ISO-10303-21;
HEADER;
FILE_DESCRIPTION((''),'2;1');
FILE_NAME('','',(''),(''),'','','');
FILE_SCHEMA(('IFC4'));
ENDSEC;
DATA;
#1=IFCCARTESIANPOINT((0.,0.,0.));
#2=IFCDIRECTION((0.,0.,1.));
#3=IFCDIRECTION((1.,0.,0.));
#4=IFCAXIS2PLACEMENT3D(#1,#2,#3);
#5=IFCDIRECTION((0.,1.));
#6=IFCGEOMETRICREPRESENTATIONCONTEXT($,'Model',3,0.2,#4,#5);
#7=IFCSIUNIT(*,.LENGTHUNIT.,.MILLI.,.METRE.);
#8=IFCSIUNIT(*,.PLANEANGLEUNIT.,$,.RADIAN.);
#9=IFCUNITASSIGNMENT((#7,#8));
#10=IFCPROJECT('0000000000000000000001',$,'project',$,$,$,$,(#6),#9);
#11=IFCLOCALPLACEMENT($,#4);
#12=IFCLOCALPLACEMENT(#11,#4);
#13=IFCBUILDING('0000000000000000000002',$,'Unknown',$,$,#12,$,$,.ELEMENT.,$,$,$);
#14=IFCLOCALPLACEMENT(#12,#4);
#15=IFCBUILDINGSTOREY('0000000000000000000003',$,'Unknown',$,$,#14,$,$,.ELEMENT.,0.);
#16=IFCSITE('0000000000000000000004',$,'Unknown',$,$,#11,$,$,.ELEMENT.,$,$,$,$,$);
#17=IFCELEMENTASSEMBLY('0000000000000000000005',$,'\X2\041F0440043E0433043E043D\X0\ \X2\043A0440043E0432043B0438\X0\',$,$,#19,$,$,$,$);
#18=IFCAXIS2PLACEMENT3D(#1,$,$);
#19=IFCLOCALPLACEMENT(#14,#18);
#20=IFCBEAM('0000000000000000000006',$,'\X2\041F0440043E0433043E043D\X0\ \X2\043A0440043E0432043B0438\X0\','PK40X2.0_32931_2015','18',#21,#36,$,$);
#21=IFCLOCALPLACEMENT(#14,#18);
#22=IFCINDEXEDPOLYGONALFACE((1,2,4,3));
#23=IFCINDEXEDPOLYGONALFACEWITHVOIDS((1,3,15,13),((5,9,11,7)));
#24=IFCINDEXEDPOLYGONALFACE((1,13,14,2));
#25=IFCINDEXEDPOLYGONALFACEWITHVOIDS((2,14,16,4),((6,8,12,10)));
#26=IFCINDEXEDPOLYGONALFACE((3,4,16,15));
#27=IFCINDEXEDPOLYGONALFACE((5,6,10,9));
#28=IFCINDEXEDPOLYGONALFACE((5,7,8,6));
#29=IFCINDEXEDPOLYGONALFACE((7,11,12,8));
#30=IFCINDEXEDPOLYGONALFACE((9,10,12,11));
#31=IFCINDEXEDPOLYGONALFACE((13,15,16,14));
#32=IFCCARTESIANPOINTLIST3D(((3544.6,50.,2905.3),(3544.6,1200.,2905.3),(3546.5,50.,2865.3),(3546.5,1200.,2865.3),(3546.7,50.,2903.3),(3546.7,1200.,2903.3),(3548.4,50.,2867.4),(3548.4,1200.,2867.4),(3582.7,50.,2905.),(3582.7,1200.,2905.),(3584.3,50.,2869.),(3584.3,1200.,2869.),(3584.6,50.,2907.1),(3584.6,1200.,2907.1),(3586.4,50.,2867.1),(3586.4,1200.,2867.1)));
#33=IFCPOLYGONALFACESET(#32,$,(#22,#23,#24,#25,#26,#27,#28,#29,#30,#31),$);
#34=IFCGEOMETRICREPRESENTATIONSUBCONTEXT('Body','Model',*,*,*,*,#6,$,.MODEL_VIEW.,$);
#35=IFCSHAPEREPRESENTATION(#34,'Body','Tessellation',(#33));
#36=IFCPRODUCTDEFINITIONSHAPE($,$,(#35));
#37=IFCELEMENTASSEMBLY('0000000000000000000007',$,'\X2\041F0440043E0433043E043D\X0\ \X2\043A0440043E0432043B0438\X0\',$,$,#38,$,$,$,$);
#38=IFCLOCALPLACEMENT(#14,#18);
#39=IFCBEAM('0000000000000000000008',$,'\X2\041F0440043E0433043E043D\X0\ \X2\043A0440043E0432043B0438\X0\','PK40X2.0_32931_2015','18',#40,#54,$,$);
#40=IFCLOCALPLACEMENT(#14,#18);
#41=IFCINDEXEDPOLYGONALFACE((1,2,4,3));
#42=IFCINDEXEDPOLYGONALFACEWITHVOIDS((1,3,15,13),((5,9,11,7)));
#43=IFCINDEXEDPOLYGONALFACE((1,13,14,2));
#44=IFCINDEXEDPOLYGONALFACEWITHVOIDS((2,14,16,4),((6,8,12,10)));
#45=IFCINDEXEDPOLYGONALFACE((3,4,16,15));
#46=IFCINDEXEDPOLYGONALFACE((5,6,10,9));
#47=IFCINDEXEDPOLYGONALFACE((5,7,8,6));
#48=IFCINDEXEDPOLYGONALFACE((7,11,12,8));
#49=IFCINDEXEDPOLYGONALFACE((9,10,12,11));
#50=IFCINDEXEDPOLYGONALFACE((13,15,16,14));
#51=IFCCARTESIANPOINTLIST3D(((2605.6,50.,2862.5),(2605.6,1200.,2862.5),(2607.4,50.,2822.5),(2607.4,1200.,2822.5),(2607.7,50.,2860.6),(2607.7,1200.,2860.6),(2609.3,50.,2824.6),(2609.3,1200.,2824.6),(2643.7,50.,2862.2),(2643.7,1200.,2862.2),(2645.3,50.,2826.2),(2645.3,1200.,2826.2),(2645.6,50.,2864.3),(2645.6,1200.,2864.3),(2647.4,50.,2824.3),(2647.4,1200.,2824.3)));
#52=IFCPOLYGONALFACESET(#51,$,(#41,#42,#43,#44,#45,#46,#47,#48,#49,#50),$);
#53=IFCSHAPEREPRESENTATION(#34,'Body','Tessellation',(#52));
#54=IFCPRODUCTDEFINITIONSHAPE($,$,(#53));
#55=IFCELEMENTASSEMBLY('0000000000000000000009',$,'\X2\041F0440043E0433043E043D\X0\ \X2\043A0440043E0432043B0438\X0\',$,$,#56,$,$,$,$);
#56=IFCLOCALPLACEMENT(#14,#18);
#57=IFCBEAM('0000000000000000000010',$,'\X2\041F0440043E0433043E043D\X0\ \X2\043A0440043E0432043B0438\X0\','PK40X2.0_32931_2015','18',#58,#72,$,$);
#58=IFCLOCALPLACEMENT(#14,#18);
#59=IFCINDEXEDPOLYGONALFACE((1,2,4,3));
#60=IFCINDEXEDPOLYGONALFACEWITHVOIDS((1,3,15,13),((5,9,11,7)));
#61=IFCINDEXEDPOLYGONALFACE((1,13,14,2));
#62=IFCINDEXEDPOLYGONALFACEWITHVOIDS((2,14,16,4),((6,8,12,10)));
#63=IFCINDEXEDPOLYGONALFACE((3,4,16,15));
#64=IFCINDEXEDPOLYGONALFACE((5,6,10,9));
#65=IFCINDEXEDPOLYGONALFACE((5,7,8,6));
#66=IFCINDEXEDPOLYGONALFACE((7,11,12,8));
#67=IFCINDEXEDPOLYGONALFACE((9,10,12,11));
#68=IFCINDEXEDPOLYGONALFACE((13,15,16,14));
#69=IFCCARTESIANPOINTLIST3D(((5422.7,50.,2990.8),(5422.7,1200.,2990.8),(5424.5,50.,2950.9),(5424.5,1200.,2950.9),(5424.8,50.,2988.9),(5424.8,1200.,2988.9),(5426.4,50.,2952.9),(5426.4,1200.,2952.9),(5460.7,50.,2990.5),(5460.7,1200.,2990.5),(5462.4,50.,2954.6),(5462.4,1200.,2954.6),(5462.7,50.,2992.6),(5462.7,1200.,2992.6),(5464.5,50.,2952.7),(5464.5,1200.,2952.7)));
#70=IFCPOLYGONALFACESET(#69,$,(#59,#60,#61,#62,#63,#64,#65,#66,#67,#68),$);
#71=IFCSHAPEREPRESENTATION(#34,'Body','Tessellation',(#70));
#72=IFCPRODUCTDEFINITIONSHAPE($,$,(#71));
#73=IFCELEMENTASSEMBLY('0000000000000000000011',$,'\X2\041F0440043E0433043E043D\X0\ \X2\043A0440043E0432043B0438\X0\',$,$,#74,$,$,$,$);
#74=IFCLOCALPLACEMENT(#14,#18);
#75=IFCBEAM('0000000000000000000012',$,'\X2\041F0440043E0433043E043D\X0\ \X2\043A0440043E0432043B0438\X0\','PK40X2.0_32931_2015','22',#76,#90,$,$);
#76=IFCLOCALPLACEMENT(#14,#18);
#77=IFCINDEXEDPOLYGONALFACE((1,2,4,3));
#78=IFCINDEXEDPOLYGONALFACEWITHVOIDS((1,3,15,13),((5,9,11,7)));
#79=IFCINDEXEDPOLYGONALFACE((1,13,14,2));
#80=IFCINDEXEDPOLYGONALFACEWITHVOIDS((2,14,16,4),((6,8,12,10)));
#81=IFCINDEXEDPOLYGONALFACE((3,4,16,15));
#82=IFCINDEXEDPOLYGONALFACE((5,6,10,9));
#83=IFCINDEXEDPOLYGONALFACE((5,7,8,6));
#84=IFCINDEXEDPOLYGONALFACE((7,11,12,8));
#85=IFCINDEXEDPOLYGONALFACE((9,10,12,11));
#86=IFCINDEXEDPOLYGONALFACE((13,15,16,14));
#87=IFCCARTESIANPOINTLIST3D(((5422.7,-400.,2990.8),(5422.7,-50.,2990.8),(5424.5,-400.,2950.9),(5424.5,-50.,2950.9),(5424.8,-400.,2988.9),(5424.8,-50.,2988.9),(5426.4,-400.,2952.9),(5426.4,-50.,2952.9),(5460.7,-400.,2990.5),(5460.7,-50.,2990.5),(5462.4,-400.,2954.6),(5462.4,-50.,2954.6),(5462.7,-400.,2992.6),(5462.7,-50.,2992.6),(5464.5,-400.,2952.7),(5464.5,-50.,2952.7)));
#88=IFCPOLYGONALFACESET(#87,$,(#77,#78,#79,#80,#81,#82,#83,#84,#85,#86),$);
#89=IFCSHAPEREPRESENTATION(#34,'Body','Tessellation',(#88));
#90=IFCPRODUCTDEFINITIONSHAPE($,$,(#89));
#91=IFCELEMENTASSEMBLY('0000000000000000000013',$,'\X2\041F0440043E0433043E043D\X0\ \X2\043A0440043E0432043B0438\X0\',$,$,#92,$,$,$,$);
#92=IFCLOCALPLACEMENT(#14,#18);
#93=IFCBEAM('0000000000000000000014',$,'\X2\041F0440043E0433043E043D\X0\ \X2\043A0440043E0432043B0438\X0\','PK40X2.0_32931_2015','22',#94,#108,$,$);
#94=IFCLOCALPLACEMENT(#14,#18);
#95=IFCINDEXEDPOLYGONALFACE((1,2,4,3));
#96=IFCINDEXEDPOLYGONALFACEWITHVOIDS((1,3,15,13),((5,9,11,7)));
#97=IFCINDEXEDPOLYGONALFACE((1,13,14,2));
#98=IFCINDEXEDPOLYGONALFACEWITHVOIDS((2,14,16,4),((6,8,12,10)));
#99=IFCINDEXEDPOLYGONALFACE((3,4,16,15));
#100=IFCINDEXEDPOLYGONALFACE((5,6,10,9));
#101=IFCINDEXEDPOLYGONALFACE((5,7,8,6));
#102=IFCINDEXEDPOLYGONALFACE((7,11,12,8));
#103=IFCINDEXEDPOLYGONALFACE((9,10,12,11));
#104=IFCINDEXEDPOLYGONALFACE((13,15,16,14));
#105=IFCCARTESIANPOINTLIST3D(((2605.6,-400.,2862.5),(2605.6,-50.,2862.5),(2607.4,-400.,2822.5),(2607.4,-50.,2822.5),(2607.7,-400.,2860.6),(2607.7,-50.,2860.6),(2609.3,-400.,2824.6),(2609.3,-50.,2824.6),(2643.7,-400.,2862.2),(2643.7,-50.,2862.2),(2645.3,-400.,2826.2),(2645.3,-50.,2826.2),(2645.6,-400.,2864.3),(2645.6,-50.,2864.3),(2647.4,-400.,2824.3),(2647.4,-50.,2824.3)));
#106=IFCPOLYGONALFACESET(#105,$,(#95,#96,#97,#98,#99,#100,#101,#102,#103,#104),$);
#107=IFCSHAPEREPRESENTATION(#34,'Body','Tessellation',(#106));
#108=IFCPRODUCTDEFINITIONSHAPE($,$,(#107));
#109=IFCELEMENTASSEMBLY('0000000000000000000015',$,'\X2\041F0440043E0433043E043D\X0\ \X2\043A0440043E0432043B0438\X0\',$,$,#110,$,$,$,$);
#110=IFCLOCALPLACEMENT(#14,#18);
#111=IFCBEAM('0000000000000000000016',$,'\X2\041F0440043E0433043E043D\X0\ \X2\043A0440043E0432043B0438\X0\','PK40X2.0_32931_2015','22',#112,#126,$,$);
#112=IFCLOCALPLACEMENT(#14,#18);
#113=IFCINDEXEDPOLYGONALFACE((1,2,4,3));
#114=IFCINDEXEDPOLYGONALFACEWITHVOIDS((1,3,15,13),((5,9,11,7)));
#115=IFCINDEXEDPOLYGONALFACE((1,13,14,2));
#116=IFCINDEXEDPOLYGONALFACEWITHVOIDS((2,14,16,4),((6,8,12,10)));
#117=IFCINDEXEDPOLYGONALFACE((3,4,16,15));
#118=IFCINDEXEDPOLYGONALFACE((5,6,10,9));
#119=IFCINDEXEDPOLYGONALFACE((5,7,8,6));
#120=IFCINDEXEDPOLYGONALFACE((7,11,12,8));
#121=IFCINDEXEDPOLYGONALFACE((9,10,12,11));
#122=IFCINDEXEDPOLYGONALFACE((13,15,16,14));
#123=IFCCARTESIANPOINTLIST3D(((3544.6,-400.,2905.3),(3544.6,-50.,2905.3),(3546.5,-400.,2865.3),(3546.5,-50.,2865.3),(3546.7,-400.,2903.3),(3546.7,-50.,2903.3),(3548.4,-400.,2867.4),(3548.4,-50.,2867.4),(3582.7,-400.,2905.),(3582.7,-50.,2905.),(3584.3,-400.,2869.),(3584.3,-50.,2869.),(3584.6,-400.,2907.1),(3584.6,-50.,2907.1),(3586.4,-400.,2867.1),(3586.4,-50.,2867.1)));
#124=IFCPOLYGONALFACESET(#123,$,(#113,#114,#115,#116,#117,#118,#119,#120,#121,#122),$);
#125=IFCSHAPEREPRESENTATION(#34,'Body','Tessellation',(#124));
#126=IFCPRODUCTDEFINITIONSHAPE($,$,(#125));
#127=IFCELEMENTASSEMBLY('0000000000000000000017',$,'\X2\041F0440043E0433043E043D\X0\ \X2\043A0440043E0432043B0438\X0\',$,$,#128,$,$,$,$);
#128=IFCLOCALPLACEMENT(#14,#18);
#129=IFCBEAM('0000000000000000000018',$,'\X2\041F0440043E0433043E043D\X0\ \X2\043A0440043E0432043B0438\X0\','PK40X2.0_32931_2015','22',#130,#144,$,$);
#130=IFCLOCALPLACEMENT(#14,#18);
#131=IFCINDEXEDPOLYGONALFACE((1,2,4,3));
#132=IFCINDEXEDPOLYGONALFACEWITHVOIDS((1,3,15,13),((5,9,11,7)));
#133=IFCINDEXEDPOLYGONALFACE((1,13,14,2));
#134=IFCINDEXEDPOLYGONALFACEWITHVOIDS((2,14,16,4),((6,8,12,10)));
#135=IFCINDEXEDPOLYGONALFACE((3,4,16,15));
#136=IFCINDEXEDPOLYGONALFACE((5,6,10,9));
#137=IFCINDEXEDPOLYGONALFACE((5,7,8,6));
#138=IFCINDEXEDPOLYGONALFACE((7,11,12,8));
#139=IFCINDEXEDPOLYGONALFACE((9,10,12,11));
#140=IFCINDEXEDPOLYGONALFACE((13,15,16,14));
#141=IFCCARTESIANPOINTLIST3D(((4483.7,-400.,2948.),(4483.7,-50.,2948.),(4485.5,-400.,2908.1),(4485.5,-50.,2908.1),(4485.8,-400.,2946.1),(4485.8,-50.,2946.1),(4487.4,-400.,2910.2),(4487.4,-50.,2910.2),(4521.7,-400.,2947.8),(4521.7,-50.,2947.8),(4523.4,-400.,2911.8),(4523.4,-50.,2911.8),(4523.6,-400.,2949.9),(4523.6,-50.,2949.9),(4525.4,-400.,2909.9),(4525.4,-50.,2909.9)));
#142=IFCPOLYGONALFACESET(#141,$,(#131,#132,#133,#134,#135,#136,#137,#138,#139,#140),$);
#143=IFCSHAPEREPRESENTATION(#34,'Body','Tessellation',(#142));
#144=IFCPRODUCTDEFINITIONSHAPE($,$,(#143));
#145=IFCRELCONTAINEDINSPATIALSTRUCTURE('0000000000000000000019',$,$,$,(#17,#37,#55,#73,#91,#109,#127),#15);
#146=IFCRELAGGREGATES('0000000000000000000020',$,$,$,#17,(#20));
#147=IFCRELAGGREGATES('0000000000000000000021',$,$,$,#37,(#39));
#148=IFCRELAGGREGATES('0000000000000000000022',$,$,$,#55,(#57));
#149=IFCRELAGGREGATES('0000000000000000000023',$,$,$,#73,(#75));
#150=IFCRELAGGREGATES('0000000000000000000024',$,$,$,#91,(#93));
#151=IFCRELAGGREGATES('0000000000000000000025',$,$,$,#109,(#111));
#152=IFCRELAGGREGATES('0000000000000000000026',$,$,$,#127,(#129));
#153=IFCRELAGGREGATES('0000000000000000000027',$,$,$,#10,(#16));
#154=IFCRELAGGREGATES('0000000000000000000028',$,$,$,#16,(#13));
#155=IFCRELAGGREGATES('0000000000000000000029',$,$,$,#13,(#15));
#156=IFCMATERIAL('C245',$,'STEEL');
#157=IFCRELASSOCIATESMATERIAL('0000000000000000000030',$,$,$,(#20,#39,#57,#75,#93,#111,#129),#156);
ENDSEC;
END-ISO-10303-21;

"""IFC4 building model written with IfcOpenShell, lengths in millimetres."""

from ifc_helpers import new_model, si_unit, direction, frame, origin_with_axes, place, context, subcontext, project, spatial, line, indexed_curve, outline, extrude, material, element, aggregate, save


model = new_model("IFC4")

# Units and contexts
model_context = context("Model", 3, precision=0.2, world=origin_with_axes(), true_north=direction((0.0, 1.0)))
body_context = subcontext(model_context, "Body", "Model", "MODEL_VIEW")
ifc_project = project(units=[si_unit("LENGTHUNIT", "METRE", prefix="MILLI"), si_unit("PLANEANGLEUNIT", "RADIAN")], contexts=[model_context])

# Site, building, storey
site_placement = place(None, origin_with_axes())
site = spatial("IfcSite", under=ifc_project, at=site_placement, Name="Unknown", CompositionType="ELEMENT")
building_placement = place(site_placement, origin_with_axes())
building = spatial("IfcBuilding", under=site, at=building_placement, Name="Unknown", CompositionType="ELEMENT")
storey_placement = place(building_placement, origin_with_axes())
storey = spatial("IfcBuildingStorey", under=building, at=storey_placement, Name="Unknown", CompositionType="ELEMENT", Elevation=0.0)

# Shared definitions
ifc_material = material(Name="C245", Category="STEEL")

# Element assemblies, beams
assembly_1_placement = place(storey_placement, frame((3565.5, 1200.0, 2886.2), z_axis=(-0.998964, 0.0, -0.045508), x_axis=(0.0, -1.0, 0.0)))
assembly_1 = element("IfcElementAssembly", 1, at=assembly_1_placement, inside=storey, Name="Прогон кровли")
beam_1_placement = place(assembly_1_placement, origin_with_axes())
beam_1 = element("IfcBeam", 2, at=beam_1_placement, material=ifc_material, Name="Прогон кровли", Description="PK40X2.0_32931_2015", ObjectType="18", context=body_context, shape_type="SolidModel", body=[
    extrude(outline(indexed_curve([(-20.0, -20.0), (20.0, -20.0), (20.0, 20.0), (-20.0, 20.0)], segments=[line(1, 2, 3, 4, 1)]), holes=[indexed_curve([(-18.0, -18.0), (-18.0, 18.0), (18.0, 18.0), (18.0, -18.0)], segments=[line(1, 2, 3, 4, 1)])]), frame((0.0, 0.0, 0.0), z_axis=(-1.0, 0.0, 0.0), x_axis=(0.0, 0.0, 1.0)), (0.0, 0.0, -1.0), 1150.0),
])
aggregate(assembly_1, [beam_1])
assembly_2_placement = place(storey_placement, frame((2626.5, 1200.0, 2843.4), z_axis=(-0.998964, 0.0, -0.045508), x_axis=(0.0, -1.0, 0.0)))
assembly_2 = element("IfcElementAssembly", 3, at=assembly_2_placement, inside=storey, Name="Прогон кровли")
beam_2_placement = place(assembly_2_placement, origin_with_axes())
beam_2 = element("IfcBeam", 4, at=beam_2_placement, material=ifc_material, Name="Прогон кровли", Description="PK40X2.0_32931_2015", ObjectType="18", context=body_context, shape_type="SolidModel", body=[
    extrude(outline(indexed_curve([(-20.0, -20.0), (20.0, -20.0), (20.0, 20.0), (-20.0, 20.0)], segments=[line(1, 2, 3, 4, 1)]), holes=[indexed_curve([(-18.0, -18.0), (-18.0, 18.0), (18.0, 18.0), (18.0, -18.0)], segments=[line(1, 2, 3, 4, 1)])]), frame((0.0, 0.0, 0.0), z_axis=(-1.0, 0.0, 0.0), x_axis=(0.0, 0.0, 1.0)), (0.0, 0.0, -1.0), 1150.0),
])
aggregate(assembly_2, [beam_2])
assembly_3_placement = place(storey_placement, frame((5443.6, 1200.0, 2971.7), z_axis=(-0.998964, 0.0, -0.045508), x_axis=(0.0, -1.0, 0.0)))
assembly_3 = element("IfcElementAssembly", 5, at=assembly_3_placement, inside=storey, Name="Прогон кровли")
beam_3_placement = place(assembly_3_placement, origin_with_axes())
beam_3 = element("IfcBeam", 6, at=beam_3_placement, material=ifc_material, Name="Прогон кровли", Description="PK40X2.0_32931_2015", ObjectType="18", context=body_context, shape_type="SolidModel", body=[
    extrude(outline(indexed_curve([(-20.0, -20.0), (20.0, -20.0), (20.0, 20.0), (-20.0, 20.0)], segments=[line(1, 2, 3, 4, 1)]), holes=[indexed_curve([(-18.0, -18.0), (-18.0, 18.0), (18.0, 18.0), (18.0, -18.0)], segments=[line(1, 2, 3, 4, 1)])]), frame((0.0, 0.0, 0.0), z_axis=(-1.0, 0.0, 0.0), x_axis=(0.0, 0.0, 1.0)), (0.0, 0.0, -1.0), 1150.0),
])
aggregate(assembly_3, [beam_3])
assembly_4_placement = place(storey_placement, frame((5443.6, -50.0, 2971.7), z_axis=(-0.998964, 0.0, -0.045508), x_axis=(0.0, -1.0, 0.0)))
assembly_4 = element("IfcElementAssembly", 7, at=assembly_4_placement, inside=storey, Name="Прогон кровли")
beam_4_placement = place(assembly_4_placement, origin_with_axes())
beam_4 = element("IfcBeam", 8, at=beam_4_placement, material=ifc_material, Name="Прогон кровли", Description="PK40X2.0_32931_2015", ObjectType="22", context=body_context, shape_type="SolidModel", body=[
    extrude(outline(indexed_curve([(-20.0, -20.0), (20.0, -20.0), (20.0, 20.0), (-20.0, 20.0)], segments=[line(1, 2, 3, 4, 1)]), holes=[indexed_curve([(-18.0, -18.0), (-18.0, 18.0), (18.0, 18.0), (18.0, -18.0)], segments=[line(1, 2, 3, 4, 1)])]), frame((0.0, 0.0, 0.0), z_axis=(-1.0, 0.0, 0.0), x_axis=(0.0, 0.0, 1.0)), (0.0, 0.0, -1.0), 350.0),
])
aggregate(assembly_4, [beam_4])
assembly_5_placement = place(storey_placement, frame((2626.5, -50.0, 2843.4), z_axis=(-0.998964, 0.0, -0.045508), x_axis=(0.0, -1.0, 0.0)))
assembly_5 = element("IfcElementAssembly", 9, at=assembly_5_placement, inside=storey, Name="Прогон кровли")
beam_5_placement = place(assembly_5_placement, origin_with_axes())
beam_5 = element("IfcBeam", 10, at=beam_5_placement, material=ifc_material, Name="Прогон кровли", Description="PK40X2.0_32931_2015", ObjectType="22", context=body_context, shape_type="SolidModel", body=[
    extrude(outline(indexed_curve([(-20.0, -20.0), (20.0, -20.0), (20.0, 20.0), (-20.0, 20.0)], segments=[line(1, 2, 3, 4, 1)]), holes=[indexed_curve([(-18.0, -18.0), (-18.0, 18.0), (18.0, 18.0), (18.0, -18.0)], segments=[line(1, 2, 3, 4, 1)])]), frame((0.0, 0.0, 0.0), z_axis=(-1.0, 0.0, 0.0), x_axis=(0.0, 0.0, 1.0)), (0.0, 0.0, -1.0), 350.0),
])
aggregate(assembly_5, [beam_5])
assembly_6_placement = place(storey_placement, frame((3565.5, -50.0, 2886.2), z_axis=(-0.998964, 0.0, -0.045508), x_axis=(0.0, -1.0, 0.0)))
assembly_6 = element("IfcElementAssembly", 11, at=assembly_6_placement, inside=storey, Name="Прогон кровли")
beam_6_placement = place(assembly_6_placement, origin_with_axes())
beam_6 = element("IfcBeam", 12, at=beam_6_placement, material=ifc_material, Name="Прогон кровли", Description="PK40X2.0_32931_2015", ObjectType="22", context=body_context, shape_type="SolidModel", body=[
    extrude(outline(indexed_curve([(-20.0, -20.0), (20.0, -20.0), (20.0, 20.0), (-20.0, 20.0)], segments=[line(1, 2, 3, 4, 1)]), holes=[indexed_curve([(-18.0, -18.0), (-18.0, 18.0), (18.0, 18.0), (18.0, -18.0)], segments=[line(1, 2, 3, 4, 1)])]), frame((0.0, 0.0, 0.0), z_axis=(-1.0, 0.0, 0.0), x_axis=(0.0, 0.0, 1.0)), (0.0, 0.0, -1.0), 350.0),
])
aggregate(assembly_6, [beam_6])
assembly_7_placement = place(storey_placement, frame((4504.6, -50.0, 2929.0), z_axis=(-0.998964, 0.0, -0.045508), x_axis=(0.0, -1.0, 0.0)))
assembly_7 = element("IfcElementAssembly", 13, at=assembly_7_placement, inside=storey, Name="Прогон кровли")
beam_7_placement = place(assembly_7_placement, origin_with_axes())
beam_7 = element("IfcBeam", 14, at=beam_7_placement, material=ifc_material, Name="Прогон кровли", Description="PK40X2.0_32931_2015", ObjectType="22", context=body_context, shape_type="SolidModel", body=[
    extrude(outline(indexed_curve([(-20.0, -20.0), (20.0, -20.0), (20.0, 20.0), (-20.0, 20.0)], segments=[line(1, 2, 3, 4, 1)]), holes=[indexed_curve([(-18.0, -18.0), (-18.0, 18.0), (18.0, 18.0), (18.0, -18.0)], segments=[line(1, 2, 3, 4, 1)])]), frame((0.0, 0.0, 0.0), z_axis=(-1.0, 0.0, 0.0), x_axis=(0.0, 0.0, 1.0)), (0.0, 0.0, -1.0), 350.0),
])
aggregate(assembly_7, [beam_7])

save(model, "model.ifc")
